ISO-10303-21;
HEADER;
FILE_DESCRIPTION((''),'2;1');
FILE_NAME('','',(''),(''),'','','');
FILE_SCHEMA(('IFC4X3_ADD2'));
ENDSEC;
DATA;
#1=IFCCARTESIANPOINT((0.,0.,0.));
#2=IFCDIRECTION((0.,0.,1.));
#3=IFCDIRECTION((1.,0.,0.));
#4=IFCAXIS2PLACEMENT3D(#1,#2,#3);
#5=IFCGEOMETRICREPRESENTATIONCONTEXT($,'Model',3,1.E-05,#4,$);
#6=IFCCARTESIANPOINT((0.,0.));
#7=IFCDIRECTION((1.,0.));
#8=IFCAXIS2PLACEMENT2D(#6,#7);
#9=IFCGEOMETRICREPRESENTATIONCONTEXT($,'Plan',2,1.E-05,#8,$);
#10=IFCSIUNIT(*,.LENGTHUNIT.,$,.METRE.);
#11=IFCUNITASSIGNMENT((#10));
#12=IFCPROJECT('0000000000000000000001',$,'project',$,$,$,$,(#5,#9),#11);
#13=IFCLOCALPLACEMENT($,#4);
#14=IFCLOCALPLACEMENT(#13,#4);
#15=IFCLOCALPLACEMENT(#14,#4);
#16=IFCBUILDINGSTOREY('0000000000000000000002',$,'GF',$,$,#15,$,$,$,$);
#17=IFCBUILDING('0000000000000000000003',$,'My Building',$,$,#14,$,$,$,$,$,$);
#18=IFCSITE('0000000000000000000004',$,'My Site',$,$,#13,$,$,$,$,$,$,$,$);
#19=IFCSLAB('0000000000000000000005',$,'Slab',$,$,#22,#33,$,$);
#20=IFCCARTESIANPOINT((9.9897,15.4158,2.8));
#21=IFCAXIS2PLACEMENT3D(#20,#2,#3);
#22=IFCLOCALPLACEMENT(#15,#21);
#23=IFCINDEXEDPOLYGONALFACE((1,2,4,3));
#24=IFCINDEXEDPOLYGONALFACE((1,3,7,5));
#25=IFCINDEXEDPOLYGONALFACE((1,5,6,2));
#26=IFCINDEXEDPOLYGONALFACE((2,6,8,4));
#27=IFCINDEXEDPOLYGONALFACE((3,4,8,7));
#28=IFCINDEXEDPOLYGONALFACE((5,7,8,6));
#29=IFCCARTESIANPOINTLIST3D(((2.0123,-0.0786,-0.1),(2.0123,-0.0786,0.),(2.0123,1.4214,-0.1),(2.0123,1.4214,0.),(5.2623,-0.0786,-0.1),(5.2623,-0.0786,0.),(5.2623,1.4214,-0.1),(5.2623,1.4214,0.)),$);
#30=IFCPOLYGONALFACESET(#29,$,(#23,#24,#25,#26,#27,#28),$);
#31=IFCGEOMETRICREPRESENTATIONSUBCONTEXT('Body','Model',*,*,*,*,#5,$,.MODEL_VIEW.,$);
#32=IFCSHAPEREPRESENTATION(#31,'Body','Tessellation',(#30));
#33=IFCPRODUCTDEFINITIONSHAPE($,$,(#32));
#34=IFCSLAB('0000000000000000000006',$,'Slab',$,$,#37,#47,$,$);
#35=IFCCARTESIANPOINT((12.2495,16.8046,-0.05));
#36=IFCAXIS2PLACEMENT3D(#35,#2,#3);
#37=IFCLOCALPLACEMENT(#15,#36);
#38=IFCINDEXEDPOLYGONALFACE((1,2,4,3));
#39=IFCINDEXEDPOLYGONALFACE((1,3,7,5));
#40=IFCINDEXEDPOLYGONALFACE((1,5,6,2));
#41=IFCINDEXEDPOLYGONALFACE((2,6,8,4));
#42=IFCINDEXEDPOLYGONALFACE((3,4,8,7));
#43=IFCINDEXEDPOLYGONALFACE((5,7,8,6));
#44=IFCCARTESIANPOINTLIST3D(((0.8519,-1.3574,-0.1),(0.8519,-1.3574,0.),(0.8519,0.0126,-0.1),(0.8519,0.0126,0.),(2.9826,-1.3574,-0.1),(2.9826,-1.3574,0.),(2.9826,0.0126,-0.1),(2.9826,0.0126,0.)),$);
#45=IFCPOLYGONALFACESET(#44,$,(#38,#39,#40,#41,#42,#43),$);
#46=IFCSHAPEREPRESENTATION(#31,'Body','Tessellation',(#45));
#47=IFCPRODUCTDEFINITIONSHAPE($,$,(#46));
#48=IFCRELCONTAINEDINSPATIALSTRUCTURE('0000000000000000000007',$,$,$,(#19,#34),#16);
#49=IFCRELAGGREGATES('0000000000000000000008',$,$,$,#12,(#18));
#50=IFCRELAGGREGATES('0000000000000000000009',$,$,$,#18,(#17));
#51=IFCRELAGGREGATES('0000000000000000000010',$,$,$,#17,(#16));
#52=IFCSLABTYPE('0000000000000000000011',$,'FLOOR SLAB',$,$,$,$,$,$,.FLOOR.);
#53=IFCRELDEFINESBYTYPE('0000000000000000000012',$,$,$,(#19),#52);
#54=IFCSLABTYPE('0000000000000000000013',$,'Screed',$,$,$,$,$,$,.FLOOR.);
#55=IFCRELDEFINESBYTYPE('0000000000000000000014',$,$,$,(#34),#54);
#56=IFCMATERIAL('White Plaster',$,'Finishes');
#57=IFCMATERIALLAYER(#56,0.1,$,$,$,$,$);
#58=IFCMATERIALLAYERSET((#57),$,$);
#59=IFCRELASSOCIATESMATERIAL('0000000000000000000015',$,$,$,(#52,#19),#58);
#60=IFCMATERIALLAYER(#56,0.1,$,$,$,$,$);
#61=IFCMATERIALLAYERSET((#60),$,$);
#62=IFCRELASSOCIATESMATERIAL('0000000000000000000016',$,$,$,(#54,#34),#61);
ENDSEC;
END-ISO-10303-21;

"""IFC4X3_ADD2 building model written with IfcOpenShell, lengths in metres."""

from ifc_helpers import new_model, si_unit, frame, origin_with_axes, origin_2d_with_axis, place, context, subcontext, project, spatial, indexed_curve, outline, extrude, material, layer, layer_set, layer_usage, type_object, element, save


model = new_model("IFC4X3_ADD2")

# Units and contexts
model_context = context("Model", 3, precision=1e-05, world=origin_with_axes())
plan_context = context("Plan", 2, precision=1e-05, world=origin_2d_with_axis())
body_context_1 = subcontext(model_context, "Body", "Model", "MODEL_VIEW")
ifc_project = project(units=[si_unit("LENGTHUNIT", "METRE")], contexts=[model_context, plan_context])

# Site, building, storey
site_placement = place(None, origin_with_axes())
site = spatial("IfcSite", under=ifc_project, at=site_placement, Name="My Site")
building_placement = place(site_placement, origin_with_axes())
building = spatial("IfcBuilding", under=site, at=building_placement, Name="My Building")
storey_placement = place(building_placement, origin_with_axes())
storey = spatial("IfcBuildingStorey", under=building, at=storey_placement, Name="GF")

# Slabs
ifc_material_1 = material(Name="White Plaster", Category="Finishes")
ifc_layer_1 = layer(ifc_material_1, 0.1)
ifc_layer_set_1 = layer_set([ifc_layer_1])
ifc_layer_usage_1 = layer_usage(ifc_layer_set_1, "AXIS3", "POSITIVE", -0.1)
slab_type_1 = type_object("IfcSlabType", Name="FLOOR SLAB", PredefinedType="FLOOR", material=ifc_layer_set_1)
slab_1_placement = place(storey_placement, frame((9.9897, 15.4158, 2.8), z_axis=(0.0, 0.0, 1.0), x_axis=(1.0, 0.0, 0.0)))
element("IfcSlab", 1, at=slab_1_placement, inside=storey, type_object=slab_type_1, material=ifc_layer_usage_1, Name="Slab", context=body_context_1, shape_type="SweptSolid", body=[
    extrude(outline(indexed_curve([(2.0123, 1.4214), (5.2623, 1.4214), (5.2623, -0.0786), (2.0123, -0.0786), (2.0123, 1.4214)])), frame((0.0, 0.0, -0.1), z_axis=(0.0, 0.0, 1.0), x_axis=(1.0, 0.0, 0.0)), (0.0, 0.0, 1.0), 0.1),
])
ifc_layer_2 = layer(ifc_material_1, 0.1)
ifc_layer_set_2 = layer_set([ifc_layer_2])
ifc_layer_usage_2 = layer_usage(ifc_layer_set_2, "AXIS3", "POSITIVE", -0.1)
slab_type_2 = type_object("IfcSlabType", Name="Screed", PredefinedType="FLOOR", material=ifc_layer_set_2)
slab_2_placement = place(storey_placement, frame((12.2495, 16.8046, -0.05), z_axis=(0.0, 0.0, 1.0), x_axis=(1.0, 0.0, 0.0)))
element("IfcSlab", 2, at=slab_2_placement, inside=storey, type_object=slab_type_2, material=ifc_layer_usage_2, Name="Slab", context=body_context_1, shape_type="SweptSolid", body=[
    extrude(outline(indexed_curve([(0.8519, -1.3574), (2.9826, -1.3574), (2.9826, 0.0126), (0.8519, 0.0126), (0.8519, -1.3574)])), frame((0.0, 0.0, -0.1), z_axis=(0.0, 0.0, 1.0), x_axis=(1.0, 0.0, 0.0)), (0.0, 0.0, 1.0), 0.1),
])

save(model, "model.ifc")
